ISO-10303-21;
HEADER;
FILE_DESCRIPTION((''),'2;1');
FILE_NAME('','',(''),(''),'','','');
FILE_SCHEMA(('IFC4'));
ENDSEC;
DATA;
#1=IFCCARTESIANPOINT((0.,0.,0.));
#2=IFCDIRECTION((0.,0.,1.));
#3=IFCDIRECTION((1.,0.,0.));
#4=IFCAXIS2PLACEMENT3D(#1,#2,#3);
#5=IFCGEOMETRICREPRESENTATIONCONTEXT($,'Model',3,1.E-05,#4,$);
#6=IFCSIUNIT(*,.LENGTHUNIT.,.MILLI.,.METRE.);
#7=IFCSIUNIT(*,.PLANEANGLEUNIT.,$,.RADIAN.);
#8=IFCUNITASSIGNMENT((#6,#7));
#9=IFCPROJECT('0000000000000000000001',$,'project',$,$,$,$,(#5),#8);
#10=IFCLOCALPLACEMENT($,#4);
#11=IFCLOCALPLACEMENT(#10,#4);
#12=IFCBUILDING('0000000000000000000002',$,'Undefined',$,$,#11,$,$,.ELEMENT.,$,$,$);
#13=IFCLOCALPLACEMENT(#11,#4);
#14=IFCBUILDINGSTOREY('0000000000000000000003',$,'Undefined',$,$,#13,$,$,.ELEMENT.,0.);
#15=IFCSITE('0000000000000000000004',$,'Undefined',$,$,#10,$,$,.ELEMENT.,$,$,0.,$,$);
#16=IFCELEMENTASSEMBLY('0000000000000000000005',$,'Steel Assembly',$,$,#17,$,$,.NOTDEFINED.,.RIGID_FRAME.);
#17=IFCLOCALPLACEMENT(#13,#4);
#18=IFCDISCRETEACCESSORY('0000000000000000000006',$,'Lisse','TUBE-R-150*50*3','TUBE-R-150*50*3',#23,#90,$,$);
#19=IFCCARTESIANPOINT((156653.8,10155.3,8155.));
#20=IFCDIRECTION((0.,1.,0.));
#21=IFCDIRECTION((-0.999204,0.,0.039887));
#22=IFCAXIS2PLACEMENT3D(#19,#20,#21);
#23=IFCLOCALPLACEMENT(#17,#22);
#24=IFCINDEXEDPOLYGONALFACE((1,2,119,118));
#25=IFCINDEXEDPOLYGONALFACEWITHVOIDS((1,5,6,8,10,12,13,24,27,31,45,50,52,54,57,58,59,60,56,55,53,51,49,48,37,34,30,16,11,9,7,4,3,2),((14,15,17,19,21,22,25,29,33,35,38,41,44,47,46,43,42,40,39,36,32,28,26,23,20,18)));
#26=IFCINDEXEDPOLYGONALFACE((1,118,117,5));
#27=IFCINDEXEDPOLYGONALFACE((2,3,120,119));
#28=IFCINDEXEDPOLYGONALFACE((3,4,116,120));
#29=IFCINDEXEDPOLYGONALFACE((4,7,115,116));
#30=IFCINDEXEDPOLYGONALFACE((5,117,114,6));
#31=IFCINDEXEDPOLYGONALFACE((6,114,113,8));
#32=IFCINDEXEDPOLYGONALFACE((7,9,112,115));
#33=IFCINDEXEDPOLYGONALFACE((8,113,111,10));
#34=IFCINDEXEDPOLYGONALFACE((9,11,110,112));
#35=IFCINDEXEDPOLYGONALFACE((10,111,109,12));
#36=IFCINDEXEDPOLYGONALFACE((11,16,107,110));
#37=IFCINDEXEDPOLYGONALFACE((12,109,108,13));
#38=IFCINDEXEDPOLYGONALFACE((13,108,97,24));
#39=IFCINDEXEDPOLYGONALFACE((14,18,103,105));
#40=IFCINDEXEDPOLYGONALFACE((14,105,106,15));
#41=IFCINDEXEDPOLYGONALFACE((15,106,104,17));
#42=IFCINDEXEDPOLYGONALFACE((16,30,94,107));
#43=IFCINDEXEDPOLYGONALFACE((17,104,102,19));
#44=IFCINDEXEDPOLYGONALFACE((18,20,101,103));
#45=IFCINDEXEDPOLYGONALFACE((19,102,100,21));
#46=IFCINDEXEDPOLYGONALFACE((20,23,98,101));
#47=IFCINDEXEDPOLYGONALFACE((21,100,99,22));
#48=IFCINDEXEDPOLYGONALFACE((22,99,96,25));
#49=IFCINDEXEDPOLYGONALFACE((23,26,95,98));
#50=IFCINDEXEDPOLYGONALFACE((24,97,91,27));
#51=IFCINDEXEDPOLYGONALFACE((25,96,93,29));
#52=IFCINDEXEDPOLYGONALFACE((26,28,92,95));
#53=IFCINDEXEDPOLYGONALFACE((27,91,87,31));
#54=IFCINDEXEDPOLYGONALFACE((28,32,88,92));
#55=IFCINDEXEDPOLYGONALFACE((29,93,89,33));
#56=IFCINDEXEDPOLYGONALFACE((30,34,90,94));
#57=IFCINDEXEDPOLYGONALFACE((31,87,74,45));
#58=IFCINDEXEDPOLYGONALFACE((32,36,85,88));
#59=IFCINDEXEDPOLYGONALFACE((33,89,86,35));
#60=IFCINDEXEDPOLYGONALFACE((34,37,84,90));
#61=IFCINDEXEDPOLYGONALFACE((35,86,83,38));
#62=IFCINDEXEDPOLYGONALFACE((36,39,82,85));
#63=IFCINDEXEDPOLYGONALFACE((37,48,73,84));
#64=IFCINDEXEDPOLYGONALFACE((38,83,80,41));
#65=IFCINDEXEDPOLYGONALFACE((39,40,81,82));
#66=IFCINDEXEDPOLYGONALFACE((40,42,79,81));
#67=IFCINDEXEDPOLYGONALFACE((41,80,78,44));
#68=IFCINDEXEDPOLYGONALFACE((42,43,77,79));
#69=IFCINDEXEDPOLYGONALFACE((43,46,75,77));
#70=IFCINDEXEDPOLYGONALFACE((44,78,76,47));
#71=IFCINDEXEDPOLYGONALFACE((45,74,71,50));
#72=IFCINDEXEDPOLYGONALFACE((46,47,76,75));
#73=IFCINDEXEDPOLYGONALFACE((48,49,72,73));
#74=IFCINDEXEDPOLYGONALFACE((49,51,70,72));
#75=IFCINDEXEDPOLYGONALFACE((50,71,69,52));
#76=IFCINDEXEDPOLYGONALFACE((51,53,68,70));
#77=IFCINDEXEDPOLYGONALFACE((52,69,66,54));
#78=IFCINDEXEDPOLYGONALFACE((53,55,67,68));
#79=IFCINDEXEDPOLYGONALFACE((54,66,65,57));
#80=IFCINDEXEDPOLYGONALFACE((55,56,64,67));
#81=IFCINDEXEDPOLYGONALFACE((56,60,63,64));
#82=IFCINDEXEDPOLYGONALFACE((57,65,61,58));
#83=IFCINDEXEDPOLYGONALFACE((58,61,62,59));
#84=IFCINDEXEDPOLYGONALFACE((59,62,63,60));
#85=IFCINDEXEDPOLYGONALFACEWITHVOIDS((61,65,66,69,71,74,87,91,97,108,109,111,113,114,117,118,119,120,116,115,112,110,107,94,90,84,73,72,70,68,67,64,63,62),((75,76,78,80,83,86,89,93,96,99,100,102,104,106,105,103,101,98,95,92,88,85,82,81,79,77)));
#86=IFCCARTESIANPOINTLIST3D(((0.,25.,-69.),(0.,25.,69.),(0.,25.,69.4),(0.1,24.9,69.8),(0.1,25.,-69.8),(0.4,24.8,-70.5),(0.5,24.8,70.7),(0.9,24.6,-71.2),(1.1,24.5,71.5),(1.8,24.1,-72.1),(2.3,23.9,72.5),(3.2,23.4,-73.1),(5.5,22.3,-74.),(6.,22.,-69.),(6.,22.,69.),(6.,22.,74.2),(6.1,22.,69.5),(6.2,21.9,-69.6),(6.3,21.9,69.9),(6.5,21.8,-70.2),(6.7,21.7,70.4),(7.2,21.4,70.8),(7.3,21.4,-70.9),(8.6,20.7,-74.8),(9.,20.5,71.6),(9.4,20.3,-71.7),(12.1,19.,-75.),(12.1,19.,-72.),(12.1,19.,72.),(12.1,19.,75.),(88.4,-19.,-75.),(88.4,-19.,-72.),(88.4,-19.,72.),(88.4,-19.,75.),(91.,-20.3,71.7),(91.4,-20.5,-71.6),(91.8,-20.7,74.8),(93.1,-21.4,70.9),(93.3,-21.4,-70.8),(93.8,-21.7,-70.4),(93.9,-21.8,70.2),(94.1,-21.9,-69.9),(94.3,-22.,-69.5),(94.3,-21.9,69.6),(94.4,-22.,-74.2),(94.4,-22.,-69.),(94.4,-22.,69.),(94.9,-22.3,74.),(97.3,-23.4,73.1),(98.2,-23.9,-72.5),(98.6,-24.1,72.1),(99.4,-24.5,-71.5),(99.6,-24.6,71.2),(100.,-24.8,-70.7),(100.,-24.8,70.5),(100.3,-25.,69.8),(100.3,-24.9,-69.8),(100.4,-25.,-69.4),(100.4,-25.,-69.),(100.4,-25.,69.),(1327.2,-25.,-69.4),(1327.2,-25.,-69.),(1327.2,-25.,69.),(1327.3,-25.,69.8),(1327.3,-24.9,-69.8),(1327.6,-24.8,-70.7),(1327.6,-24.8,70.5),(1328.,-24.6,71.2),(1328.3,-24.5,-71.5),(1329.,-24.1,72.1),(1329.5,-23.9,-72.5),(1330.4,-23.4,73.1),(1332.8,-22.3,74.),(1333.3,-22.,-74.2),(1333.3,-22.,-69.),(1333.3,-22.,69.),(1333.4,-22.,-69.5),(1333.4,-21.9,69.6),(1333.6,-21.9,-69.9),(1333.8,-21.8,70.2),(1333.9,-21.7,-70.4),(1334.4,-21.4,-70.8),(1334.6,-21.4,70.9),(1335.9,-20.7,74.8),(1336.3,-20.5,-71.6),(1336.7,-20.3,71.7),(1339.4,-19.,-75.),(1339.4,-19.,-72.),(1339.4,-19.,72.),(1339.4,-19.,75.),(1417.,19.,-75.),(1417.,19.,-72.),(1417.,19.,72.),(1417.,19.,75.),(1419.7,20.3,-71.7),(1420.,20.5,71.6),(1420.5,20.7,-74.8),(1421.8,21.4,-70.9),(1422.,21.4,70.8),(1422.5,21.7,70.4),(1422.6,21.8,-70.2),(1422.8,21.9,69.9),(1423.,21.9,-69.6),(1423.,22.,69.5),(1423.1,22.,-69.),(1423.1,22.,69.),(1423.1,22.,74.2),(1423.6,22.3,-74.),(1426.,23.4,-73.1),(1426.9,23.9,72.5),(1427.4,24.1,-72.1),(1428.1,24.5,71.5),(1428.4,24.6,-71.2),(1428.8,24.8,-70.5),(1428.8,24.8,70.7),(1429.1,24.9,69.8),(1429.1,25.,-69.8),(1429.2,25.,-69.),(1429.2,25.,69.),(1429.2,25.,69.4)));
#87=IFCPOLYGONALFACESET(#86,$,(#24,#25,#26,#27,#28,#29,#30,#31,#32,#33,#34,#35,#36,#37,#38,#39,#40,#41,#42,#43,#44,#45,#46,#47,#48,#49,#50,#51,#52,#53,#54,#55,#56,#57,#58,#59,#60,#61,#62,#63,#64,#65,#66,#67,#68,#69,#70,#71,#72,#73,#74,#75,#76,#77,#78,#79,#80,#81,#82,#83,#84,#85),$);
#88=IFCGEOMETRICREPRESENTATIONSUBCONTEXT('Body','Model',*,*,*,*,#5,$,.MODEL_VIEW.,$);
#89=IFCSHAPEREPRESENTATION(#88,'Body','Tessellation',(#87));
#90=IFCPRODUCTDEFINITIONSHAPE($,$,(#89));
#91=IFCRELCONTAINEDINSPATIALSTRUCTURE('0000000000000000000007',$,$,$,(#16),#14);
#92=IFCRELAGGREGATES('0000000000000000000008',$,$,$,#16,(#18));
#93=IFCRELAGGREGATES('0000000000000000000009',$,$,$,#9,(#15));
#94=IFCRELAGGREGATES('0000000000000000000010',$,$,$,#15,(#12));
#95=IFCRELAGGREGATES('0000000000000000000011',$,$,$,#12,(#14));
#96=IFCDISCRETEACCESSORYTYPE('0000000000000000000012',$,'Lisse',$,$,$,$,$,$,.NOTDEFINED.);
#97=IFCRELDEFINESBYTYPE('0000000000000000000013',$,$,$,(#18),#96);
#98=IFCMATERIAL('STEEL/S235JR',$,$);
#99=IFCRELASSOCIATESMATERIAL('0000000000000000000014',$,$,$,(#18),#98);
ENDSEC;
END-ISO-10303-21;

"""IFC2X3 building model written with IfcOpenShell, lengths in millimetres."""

from ifc_helpers import new_model, si_unit, frame, origin_with_axes, origin_2d_with_axis, place, context, subcontext, project, spatial, hollow_rectangle, extrude, clip, halfspace, material, type_object, element, aggregate, save


model = new_model("IFC2X3")

# Units and contexts
model_context = context("Model", 3, precision=1e-05, world=origin_with_axes())
body_context = subcontext(model_context, "Body", "Model", "MODEL_VIEW")
ifc_project = project(units=[si_unit("LENGTHUNIT", "METRE", prefix="MILLI"), si_unit("PLANEANGLEUNIT", "RADIAN")], contexts=[model_context])

# Site, building, storey
site_placement = place(None, origin_with_axes())
site = spatial("IfcSite", under=ifc_project, at=site_placement, Name="Undefined", CompositionType="ELEMENT", RefElevation=0.0)
building_placement = place(site_placement, origin_with_axes())
building = spatial("IfcBuilding", under=site, at=building_placement, Name="Undefined", CompositionType="ELEMENT")
storey_placement = place(building_placement, origin_with_axes())
storey = spatial("IfcBuildingStorey", under=building, at=storey_placement, Name="Undefined", CompositionType="ELEMENT", Elevation=0.0)

# Shared definitions
ifc_material_1 = material(Name="STEEL/S235JR")

# Shared definitions
discrete_accessory_type_1 = type_object("IfcDiscreteAccessoryType", Name="Lisse")

# Element assembly, discrete accessory
assembly_1_placement = place(storey_placement, origin_with_axes())
assembly_1 = element("IfcElementAssembly", 1, at=assembly_1_placement, inside=storey, Name="Steel Assembly", AssemblyPlace="NOTDEFINED", PredefinedType="RIGID_FRAME")
discrete_accessory_1_placement = place(assembly_1_placement, frame((156653.8, 10155.3, 8155.0), z_axis=(0.0, 1.0, 0.0), x_axis=(-0.999204, 0.0, 0.039887)))
discrete_accessory_1 = element("IfcDiscreteAccessory", 2, at=discrete_accessory_1_placement, type_object=discrete_accessory_type_1, material=ifc_material_1, Name="Lisse", Description="TUBE-R-150*50*3", ObjectType="TUBE-R-150*50*3", context=body_context, shape_type="Clipping", body=[
    clip(clip(extrude(hollow_rectangle(XDim=50.0, YDim=150.0, WallThickness=3.0, InnerFilletRadius=3.0, OuterFilletRadius=6.0, at=origin_2d_with_axis()), frame((1482.3, 0.0, 0.0), z_axis=(-1.0, 0.0, 0.0), x_axis=(0.0, -1.0, 0.0)), (0.0, 0.0, 1.0), 1536.2), halfspace(frame((1327.2, -25.0, 0.0), z_axis=(-0.439894, 0.89805, 0.0), x_axis=(0.0, 0.0, -1.0)), True)), halfspace(frame((100.4, -25.0, 0.0), z_axis=(-0.445677, -0.895194, 0.0), x_axis=(0.0, 0.0, -1.0)), False)),
])
aggregate(assembly_1, [discrete_accessory_1])

save(model, "model.ifc")
